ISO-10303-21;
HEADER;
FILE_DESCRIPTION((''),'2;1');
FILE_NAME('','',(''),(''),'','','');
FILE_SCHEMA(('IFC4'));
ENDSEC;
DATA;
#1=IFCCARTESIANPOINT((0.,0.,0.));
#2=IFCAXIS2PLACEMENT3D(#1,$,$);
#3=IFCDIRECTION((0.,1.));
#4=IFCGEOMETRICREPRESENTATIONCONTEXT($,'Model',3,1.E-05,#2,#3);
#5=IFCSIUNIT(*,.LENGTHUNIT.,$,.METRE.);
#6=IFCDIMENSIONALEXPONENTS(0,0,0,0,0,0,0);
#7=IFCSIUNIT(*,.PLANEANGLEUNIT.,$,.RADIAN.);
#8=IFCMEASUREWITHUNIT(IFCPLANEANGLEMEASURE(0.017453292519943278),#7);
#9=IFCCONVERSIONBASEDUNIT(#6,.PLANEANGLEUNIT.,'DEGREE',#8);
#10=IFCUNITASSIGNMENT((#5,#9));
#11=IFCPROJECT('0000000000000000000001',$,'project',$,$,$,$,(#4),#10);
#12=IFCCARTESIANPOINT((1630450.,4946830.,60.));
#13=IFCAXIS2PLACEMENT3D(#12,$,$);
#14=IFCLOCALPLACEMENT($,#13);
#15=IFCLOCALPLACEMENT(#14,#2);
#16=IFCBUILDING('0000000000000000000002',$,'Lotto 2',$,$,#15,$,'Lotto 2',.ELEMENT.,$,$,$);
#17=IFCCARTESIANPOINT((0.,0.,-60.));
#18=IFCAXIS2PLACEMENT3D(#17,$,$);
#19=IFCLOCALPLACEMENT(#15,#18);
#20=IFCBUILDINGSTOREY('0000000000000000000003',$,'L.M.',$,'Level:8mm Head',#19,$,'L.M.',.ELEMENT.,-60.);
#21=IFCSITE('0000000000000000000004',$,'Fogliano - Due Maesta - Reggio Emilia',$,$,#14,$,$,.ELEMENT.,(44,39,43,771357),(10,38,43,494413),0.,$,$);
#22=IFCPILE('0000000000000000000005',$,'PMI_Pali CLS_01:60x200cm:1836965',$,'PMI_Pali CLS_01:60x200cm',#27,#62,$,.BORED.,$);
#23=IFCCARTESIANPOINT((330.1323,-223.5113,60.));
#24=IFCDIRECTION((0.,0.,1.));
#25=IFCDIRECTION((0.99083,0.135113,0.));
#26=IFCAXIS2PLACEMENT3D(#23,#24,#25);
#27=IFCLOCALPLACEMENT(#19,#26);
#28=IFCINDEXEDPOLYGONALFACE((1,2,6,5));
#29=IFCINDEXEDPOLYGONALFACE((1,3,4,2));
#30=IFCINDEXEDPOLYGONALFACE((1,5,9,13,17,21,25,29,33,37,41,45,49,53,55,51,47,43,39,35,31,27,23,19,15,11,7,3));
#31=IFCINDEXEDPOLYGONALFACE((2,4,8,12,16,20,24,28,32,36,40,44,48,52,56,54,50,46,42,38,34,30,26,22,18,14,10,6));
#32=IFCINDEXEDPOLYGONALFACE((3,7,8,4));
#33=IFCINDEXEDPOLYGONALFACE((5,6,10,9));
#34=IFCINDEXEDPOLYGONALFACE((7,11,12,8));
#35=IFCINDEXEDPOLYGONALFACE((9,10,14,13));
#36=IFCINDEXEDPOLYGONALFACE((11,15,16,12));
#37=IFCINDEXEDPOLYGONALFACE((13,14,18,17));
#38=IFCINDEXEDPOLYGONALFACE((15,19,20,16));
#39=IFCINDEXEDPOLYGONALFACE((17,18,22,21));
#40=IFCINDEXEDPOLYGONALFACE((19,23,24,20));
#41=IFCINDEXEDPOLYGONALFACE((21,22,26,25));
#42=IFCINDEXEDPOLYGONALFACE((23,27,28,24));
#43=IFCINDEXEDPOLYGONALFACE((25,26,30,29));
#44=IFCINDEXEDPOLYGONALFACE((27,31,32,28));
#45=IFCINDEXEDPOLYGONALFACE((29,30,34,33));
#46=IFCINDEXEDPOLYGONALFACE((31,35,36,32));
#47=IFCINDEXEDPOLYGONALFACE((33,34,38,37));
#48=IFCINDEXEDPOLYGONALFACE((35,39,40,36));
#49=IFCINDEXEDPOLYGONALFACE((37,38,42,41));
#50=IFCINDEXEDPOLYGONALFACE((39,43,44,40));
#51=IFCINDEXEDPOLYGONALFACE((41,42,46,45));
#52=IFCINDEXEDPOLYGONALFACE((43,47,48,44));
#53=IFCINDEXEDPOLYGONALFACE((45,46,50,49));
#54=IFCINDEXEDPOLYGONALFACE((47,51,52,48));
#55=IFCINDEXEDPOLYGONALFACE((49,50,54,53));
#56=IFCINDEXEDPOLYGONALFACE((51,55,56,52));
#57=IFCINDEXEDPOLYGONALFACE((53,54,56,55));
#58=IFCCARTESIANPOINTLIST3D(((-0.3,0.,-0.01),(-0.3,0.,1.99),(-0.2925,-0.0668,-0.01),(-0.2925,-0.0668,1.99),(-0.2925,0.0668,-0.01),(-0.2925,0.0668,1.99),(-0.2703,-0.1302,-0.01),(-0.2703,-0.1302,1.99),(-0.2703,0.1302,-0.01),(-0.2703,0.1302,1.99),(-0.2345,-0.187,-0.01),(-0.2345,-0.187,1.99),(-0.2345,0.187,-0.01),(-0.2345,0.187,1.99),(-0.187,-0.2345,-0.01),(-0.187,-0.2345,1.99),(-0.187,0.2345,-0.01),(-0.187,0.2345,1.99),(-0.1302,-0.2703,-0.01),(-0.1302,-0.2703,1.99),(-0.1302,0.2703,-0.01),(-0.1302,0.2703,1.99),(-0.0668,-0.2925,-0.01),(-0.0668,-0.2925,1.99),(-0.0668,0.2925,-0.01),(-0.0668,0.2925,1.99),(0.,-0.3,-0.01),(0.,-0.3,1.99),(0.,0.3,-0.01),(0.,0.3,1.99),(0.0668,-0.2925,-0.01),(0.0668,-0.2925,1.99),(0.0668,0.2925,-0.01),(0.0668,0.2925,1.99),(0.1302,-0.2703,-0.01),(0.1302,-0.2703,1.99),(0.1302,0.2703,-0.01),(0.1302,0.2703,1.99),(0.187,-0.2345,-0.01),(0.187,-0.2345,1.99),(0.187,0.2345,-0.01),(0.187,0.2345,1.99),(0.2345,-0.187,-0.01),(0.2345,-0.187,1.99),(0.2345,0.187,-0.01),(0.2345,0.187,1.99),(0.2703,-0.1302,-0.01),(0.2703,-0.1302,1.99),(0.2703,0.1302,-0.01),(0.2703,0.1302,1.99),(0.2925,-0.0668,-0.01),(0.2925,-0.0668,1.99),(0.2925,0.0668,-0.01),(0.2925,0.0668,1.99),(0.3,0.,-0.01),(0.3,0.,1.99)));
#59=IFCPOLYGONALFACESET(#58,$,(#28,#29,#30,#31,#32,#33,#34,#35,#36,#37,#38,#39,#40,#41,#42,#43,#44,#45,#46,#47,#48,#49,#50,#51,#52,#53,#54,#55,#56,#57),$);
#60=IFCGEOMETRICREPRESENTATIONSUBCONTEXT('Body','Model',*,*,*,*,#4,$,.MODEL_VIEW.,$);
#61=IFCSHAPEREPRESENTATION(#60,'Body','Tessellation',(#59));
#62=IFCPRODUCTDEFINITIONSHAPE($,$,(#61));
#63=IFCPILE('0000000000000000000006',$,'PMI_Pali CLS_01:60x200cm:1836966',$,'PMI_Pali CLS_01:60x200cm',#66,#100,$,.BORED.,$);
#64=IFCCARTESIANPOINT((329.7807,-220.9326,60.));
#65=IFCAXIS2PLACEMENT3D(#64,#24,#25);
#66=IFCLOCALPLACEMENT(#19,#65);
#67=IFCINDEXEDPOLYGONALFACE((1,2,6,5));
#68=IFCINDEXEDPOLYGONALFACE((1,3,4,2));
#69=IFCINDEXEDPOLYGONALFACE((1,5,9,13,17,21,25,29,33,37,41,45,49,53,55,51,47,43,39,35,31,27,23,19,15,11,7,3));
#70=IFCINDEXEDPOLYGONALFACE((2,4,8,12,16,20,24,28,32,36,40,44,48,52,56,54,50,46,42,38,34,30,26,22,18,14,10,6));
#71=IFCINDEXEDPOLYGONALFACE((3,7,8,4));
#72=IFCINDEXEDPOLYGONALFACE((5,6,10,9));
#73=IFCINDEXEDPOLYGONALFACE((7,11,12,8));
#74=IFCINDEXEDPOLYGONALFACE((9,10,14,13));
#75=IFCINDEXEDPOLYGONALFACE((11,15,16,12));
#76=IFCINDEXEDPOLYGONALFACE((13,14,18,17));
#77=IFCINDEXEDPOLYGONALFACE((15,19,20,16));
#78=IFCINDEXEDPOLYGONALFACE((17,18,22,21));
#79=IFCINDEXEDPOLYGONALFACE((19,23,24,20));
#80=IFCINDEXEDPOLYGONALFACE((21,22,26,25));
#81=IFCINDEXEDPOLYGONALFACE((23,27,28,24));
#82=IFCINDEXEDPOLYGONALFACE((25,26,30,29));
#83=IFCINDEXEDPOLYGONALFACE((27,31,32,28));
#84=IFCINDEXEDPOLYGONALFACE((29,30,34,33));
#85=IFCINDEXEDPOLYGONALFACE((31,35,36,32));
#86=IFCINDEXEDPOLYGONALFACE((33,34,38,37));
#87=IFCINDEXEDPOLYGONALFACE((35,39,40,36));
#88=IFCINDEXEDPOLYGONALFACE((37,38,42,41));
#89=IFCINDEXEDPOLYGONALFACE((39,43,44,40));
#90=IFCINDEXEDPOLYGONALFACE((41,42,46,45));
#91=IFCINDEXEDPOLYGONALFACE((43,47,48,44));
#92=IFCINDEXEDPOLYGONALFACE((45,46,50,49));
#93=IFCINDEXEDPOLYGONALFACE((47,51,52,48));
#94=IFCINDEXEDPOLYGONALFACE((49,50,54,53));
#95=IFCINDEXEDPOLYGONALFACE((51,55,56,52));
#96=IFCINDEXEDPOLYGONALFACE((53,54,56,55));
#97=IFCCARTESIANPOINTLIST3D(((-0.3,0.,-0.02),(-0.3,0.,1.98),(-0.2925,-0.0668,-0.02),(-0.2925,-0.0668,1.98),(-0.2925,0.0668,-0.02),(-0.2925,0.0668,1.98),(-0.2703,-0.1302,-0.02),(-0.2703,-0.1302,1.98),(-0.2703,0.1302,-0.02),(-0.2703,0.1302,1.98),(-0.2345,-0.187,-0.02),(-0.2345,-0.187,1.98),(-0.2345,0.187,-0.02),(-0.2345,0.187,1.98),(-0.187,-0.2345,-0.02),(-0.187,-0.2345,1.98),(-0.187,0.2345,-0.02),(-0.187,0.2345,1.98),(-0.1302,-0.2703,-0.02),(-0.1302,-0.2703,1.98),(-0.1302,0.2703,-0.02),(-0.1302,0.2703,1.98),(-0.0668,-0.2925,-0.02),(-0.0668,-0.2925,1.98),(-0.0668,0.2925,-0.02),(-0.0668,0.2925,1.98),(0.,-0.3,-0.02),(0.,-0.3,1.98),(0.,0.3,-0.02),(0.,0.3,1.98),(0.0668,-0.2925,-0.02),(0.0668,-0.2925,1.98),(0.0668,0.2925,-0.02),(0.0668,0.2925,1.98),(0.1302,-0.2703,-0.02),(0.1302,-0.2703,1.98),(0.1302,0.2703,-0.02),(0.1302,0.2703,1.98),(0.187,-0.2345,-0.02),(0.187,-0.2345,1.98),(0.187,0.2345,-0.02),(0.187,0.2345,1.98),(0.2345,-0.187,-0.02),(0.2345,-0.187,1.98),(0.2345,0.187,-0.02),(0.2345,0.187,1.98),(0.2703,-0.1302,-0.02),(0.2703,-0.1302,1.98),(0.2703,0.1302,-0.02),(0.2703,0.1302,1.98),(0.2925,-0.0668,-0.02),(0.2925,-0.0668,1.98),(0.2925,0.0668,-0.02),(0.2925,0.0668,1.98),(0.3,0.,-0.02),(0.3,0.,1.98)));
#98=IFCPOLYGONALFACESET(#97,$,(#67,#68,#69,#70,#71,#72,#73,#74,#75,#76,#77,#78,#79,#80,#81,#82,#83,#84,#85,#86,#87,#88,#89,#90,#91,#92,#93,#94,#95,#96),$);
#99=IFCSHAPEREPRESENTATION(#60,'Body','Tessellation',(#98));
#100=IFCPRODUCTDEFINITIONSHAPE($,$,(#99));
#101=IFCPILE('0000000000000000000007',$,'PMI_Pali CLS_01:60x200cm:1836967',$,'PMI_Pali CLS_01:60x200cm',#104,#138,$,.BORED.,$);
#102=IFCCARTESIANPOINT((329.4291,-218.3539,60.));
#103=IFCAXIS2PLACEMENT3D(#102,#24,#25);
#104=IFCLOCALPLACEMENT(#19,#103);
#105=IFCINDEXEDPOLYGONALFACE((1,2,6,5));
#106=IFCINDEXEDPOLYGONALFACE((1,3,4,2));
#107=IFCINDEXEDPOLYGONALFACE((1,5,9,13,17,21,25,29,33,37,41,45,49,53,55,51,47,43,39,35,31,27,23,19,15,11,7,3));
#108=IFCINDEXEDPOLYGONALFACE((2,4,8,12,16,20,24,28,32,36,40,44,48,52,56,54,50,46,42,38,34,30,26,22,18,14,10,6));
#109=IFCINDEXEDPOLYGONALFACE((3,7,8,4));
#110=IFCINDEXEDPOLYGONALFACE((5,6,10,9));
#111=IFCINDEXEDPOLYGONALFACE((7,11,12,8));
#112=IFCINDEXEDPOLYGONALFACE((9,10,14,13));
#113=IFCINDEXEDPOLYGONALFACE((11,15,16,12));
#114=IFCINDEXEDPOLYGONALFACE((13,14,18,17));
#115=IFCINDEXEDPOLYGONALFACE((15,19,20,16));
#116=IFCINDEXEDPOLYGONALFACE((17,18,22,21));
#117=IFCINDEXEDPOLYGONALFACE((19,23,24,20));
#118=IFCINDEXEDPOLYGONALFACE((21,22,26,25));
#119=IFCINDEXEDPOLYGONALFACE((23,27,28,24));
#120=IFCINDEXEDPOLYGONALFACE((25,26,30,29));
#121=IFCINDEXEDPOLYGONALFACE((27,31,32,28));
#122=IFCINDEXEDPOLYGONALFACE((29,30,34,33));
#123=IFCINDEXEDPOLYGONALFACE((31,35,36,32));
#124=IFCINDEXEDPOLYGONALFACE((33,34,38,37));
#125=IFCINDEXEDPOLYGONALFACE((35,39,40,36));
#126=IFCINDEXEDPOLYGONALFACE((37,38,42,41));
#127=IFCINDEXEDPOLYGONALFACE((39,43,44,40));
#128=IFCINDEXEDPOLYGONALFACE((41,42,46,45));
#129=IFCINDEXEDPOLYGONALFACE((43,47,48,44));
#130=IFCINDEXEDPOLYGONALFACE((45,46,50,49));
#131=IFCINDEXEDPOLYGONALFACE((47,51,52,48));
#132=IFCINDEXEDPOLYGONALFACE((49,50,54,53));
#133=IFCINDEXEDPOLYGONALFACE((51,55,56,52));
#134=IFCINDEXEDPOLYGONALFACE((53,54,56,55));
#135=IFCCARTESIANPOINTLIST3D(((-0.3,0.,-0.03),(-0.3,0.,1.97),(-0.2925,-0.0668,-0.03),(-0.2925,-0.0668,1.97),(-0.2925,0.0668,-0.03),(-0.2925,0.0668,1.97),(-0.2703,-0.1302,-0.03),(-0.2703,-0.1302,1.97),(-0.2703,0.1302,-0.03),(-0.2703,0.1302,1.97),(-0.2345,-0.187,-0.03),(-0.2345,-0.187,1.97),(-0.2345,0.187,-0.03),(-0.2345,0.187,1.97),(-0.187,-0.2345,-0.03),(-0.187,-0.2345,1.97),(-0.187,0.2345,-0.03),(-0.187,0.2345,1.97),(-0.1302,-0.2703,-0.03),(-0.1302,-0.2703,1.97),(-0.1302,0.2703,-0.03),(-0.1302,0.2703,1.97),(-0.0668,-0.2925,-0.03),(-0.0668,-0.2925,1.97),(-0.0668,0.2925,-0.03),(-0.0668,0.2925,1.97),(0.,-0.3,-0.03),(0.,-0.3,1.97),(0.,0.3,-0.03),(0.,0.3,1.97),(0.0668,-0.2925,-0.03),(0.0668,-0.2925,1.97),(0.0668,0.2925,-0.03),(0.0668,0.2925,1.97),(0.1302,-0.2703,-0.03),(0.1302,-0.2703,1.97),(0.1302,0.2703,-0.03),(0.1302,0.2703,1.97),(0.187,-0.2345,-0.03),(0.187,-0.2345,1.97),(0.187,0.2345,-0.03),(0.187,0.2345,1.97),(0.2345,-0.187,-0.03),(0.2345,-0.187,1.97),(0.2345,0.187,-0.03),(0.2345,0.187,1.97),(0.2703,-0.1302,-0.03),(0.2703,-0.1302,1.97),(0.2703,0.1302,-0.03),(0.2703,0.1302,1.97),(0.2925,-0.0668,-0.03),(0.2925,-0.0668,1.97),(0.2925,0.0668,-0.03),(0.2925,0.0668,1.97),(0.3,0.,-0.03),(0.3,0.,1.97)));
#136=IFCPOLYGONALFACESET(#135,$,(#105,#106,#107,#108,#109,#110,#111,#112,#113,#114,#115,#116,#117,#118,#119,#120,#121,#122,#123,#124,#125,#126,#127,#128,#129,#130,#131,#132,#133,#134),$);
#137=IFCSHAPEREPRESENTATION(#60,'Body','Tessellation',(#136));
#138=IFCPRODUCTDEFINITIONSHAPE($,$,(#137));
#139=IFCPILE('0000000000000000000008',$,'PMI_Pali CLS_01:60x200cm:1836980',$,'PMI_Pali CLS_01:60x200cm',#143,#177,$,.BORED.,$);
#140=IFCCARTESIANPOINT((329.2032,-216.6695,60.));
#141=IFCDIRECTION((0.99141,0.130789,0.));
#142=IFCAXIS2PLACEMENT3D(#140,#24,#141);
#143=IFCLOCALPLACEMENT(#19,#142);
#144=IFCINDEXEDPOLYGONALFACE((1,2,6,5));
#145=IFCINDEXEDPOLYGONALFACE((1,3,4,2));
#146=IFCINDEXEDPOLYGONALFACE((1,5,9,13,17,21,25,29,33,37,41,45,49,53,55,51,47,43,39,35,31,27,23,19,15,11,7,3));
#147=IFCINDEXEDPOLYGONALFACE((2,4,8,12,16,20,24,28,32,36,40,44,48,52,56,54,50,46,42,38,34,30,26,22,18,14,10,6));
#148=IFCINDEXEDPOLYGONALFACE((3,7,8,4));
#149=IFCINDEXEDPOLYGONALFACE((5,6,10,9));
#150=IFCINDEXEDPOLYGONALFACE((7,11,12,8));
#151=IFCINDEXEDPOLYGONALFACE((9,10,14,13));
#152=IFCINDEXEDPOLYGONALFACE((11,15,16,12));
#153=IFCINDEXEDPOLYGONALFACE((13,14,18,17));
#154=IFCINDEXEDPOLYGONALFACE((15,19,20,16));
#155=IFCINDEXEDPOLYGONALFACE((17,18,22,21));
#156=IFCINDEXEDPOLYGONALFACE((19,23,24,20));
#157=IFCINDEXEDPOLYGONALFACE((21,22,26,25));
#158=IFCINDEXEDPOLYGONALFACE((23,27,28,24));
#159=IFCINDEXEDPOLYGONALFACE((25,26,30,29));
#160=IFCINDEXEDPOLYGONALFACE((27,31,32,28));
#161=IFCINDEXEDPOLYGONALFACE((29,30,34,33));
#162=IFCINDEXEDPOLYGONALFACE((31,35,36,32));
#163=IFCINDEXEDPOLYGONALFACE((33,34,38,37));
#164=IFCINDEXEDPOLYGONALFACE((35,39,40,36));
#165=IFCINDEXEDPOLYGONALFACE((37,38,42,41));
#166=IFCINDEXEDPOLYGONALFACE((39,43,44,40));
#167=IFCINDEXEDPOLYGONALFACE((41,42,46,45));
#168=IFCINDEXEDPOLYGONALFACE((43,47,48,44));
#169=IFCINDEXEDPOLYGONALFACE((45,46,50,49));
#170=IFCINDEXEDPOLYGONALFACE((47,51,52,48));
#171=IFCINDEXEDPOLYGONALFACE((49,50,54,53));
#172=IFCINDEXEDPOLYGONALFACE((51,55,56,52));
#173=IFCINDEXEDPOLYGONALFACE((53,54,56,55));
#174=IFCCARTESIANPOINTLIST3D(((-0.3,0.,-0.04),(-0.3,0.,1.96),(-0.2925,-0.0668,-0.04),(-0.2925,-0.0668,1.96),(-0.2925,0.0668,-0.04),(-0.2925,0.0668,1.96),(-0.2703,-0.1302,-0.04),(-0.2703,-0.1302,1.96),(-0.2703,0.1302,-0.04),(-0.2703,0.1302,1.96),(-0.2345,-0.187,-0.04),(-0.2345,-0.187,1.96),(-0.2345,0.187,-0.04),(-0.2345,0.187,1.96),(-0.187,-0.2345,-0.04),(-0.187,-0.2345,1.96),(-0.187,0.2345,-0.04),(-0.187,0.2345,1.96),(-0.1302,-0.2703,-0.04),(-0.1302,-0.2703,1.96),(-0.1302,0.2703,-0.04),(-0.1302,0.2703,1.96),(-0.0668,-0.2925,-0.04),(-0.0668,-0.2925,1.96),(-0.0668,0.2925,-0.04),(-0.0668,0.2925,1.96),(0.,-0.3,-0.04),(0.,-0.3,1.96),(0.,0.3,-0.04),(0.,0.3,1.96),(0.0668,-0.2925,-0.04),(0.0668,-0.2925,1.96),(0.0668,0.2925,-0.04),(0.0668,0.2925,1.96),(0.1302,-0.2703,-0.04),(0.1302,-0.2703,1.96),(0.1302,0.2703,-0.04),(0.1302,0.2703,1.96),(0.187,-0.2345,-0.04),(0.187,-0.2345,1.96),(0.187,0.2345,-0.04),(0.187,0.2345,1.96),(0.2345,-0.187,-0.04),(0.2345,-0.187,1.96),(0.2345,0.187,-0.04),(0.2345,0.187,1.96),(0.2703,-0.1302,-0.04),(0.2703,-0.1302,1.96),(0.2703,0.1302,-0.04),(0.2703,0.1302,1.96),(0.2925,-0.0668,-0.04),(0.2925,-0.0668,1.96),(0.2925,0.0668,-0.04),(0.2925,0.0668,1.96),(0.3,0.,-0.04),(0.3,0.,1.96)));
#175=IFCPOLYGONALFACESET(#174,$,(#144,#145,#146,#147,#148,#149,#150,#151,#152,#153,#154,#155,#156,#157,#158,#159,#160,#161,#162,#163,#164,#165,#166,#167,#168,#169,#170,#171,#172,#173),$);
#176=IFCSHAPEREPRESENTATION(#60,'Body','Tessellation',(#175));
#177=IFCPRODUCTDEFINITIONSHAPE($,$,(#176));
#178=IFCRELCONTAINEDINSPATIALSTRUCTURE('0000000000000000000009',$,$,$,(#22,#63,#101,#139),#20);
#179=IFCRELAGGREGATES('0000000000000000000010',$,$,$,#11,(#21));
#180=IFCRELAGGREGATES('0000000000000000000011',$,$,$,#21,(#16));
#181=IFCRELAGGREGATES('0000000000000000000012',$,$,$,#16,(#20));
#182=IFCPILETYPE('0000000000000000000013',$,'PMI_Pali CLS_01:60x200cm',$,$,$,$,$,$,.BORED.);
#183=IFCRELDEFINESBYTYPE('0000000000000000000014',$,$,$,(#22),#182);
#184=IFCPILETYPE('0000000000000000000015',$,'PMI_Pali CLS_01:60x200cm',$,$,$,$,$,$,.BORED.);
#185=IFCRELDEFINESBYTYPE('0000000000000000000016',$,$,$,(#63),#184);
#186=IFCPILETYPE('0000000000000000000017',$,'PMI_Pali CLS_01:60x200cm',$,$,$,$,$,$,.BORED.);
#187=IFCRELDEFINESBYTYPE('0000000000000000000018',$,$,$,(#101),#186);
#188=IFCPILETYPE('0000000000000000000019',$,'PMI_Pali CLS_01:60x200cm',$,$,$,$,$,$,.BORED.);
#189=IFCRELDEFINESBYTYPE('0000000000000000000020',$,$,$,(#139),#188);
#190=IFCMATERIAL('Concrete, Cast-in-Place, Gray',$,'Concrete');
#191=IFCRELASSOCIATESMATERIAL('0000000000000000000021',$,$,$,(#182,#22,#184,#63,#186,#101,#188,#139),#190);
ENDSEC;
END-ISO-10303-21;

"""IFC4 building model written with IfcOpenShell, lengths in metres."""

from ifc_helpers import new_model, entity, si_unit, converted_unit, direction, frame, origin, place, context, subcontext, project, spatial, arc, indexed_curve, outline, extrude, source, transform, mapped, material, type_object, type_shapes, element, save


model = new_model("IFC4")

# Units and contexts
model_context = context("Model", 3, precision=1e-05, world=origin(), true_north=direction((0.0, 1.0)))
body_context = subcontext(model_context, "Body", "Model", "MODEL_VIEW")
ifc_project = project(units=[si_unit("LENGTHUNIT", "METRE"), converted_unit("PLANEANGLEUNIT", "DEGREE", entity("IfcPlaneAngleMeasure", 0.017453292519943278), si_unit("PLANEANGLEUNIT", "RADIAN"), dimensions=[0, 0, 0, 0, 0, 0, 0])], contexts=[model_context])

# Site, building, storey
site_placement = place(None, frame((1630450.0, 4946830.0, 60.0)))
site = spatial("IfcSite", under=ifc_project, at=site_placement, Name="Fogliano - Due Maesta - Reggio Emilia", CompositionType="ELEMENT", RefLatitude=(44, 39, 43, 771357), RefLongitude=(10, 38, 43, 494413), RefElevation=0.0)
building_placement = place(site_placement, origin())
building = spatial("IfcBuilding", under=site, at=building_placement, Name="Lotto 2", LongName="Lotto 2", CompositionType="ELEMENT")
storey_placement = place(building_placement, frame((0.0, 0.0, -60.0)))
storey = spatial("IfcBuildingStorey", under=building, at=storey_placement, Name="L.M.", ObjectType="Level:8mm Head", LongName="L.M.", CompositionType="ELEMENT", Elevation=-60.0)

# Piles
ifc_material_1 = material(Name="Concrete, Cast-in-Place, Gray", Category="Concrete")
pile_type_1 = type_object("IfcPileType", Name="PMI_Pali CLS_01:60x200cm", PredefinedType="BORED", material=ifc_material_1)
shared_shape_1 = source(origin(), body_context, "Body", "SweptSolid", [
    extrude(outline(indexed_curve([(-0.3, 0.0), (0.0, -0.3), (0.3, 0.0), (0.0, 0.3)], segments=[arc(1, 2, 3), arc(3, 4, 1)], self_intersect=False)), frame((0.0, 0.0, -0.01)), (0.0, 0.0, 1.0), 2.0),
])
type_shapes(pile_type_1, [shared_shape_1])
pile_1_placement = place(storey_placement, frame((330.1323, -223.5113, 60.0), z_axis=(0.0, 0.0, 1.0), x_axis=(0.99083, 0.135113, 0.0)))
element("IfcPile", 1, at=pile_1_placement, inside=storey, type_object=pile_type_1, material=ifc_material_1, Name="PMI_Pali CLS_01:60x200cm:1836965", ObjectType="PMI_Pali CLS_01:60x200cm", PredefinedType="BORED", context=body_context, shape_type="MappedRepresentation", body=[
    mapped(shared_shape_1, transform((0.0, 0.0, 0.0), scale=1.0)),
])
pile_type_2 = type_object("IfcPileType", Name="PMI_Pali CLS_01:60x200cm", PredefinedType="BORED", material=ifc_material_1)
shared_shape_2 = source(origin(), body_context, "Body", "SweptSolid", [
    extrude(outline(indexed_curve([(-0.3, 0.0), (0.0, -0.3), (0.3, 0.0), (0.0, 0.3)], segments=[arc(1, 2, 3), arc(3, 4, 1)], self_intersect=False)), frame((0.0, 0.0, -0.02)), (0.0, 0.0, 1.0), 2.0),
])
type_shapes(pile_type_2, [shared_shape_2])
pile_2_placement = place(storey_placement, frame((329.7807, -220.9326, 60.0), z_axis=(0.0, 0.0, 1.0), x_axis=(0.99083, 0.135113, 0.0)))
element("IfcPile", 2, at=pile_2_placement, inside=storey, type_object=pile_type_2, material=ifc_material_1, Name="PMI_Pali CLS_01:60x200cm:1836966", ObjectType="PMI_Pali CLS_01:60x200cm", PredefinedType="BORED", context=body_context, shape_type="MappedRepresentation", body=[
    mapped(shared_shape_2, transform((0.0, 0.0, 0.0), scale=1.0)),
])
pile_type_3 = type_object("IfcPileType", Name="PMI_Pali CLS_01:60x200cm", PredefinedType="BORED", material=ifc_material_1)
shared_shape_3 = source(origin(), body_context, "Body", "SweptSolid", [
    extrude(outline(indexed_curve([(-0.3, 0.0), (0.0, -0.3), (0.3, 0.0), (0.0, 0.3)], segments=[arc(1, 2, 3), arc(3, 4, 1)], self_intersect=False)), frame((0.0, 0.0, -0.03)), (0.0, 0.0, 1.0), 2.0),
])
type_shapes(pile_type_3, [shared_shape_3])
pile_3_placement = place(storey_placement, frame((329.4291, -218.3539, 60.0), z_axis=(0.0, 0.0, 1.0), x_axis=(0.99083, 0.135113, 0.0)))
element("IfcPile", 3, at=pile_3_placement, inside=storey, type_object=pile_type_3, material=ifc_material_1, Name="PMI_Pali CLS_01:60x200cm:1836967", ObjectType="PMI_Pali CLS_01:60x200cm", PredefinedType="BORED", context=body_context, shape_type="MappedRepresentation", body=[
    mapped(shared_shape_3, transform((0.0, 0.0, 0.0), scale=1.0)),
])
pile_type_4 = type_object("IfcPileType", Name="PMI_Pali CLS_01:60x200cm", PredefinedType="BORED", material=ifc_material_1)
shared_shape_4 = source(origin(), body_context, "Body", "SweptSolid", [
    extrude(outline(indexed_curve([(-0.3, 0.0), (0.0, -0.3), (0.3, 0.0), (0.0, 0.3)], segments=[arc(1, 2, 3), arc(3, 4, 1)], self_intersect=False)), frame((0.0, 0.0, -0.04)), (0.0, 0.0, 1.0), 2.0),
])
type_shapes(pile_type_4, [shared_shape_4])
pile_4_placement = place(storey_placement, frame((329.2032, -216.6695, 60.0), z_axis=(0.0, 0.0, 1.0), x_axis=(0.99141, 0.130789, 0.0)))
element("IfcPile", 4, at=pile_4_placement, inside=storey, type_object=pile_type_4, material=ifc_material_1, Name="PMI_Pali CLS_01:60x200cm:1836980", ObjectType="PMI_Pali CLS_01:60x200cm", PredefinedType="BORED", context=body_context, shape_type="MappedRepresentation", body=[
    mapped(shared_shape_4, transform((0.0, 0.0, 0.0), scale=1.0)),
])

save(model, "model.ifc")
